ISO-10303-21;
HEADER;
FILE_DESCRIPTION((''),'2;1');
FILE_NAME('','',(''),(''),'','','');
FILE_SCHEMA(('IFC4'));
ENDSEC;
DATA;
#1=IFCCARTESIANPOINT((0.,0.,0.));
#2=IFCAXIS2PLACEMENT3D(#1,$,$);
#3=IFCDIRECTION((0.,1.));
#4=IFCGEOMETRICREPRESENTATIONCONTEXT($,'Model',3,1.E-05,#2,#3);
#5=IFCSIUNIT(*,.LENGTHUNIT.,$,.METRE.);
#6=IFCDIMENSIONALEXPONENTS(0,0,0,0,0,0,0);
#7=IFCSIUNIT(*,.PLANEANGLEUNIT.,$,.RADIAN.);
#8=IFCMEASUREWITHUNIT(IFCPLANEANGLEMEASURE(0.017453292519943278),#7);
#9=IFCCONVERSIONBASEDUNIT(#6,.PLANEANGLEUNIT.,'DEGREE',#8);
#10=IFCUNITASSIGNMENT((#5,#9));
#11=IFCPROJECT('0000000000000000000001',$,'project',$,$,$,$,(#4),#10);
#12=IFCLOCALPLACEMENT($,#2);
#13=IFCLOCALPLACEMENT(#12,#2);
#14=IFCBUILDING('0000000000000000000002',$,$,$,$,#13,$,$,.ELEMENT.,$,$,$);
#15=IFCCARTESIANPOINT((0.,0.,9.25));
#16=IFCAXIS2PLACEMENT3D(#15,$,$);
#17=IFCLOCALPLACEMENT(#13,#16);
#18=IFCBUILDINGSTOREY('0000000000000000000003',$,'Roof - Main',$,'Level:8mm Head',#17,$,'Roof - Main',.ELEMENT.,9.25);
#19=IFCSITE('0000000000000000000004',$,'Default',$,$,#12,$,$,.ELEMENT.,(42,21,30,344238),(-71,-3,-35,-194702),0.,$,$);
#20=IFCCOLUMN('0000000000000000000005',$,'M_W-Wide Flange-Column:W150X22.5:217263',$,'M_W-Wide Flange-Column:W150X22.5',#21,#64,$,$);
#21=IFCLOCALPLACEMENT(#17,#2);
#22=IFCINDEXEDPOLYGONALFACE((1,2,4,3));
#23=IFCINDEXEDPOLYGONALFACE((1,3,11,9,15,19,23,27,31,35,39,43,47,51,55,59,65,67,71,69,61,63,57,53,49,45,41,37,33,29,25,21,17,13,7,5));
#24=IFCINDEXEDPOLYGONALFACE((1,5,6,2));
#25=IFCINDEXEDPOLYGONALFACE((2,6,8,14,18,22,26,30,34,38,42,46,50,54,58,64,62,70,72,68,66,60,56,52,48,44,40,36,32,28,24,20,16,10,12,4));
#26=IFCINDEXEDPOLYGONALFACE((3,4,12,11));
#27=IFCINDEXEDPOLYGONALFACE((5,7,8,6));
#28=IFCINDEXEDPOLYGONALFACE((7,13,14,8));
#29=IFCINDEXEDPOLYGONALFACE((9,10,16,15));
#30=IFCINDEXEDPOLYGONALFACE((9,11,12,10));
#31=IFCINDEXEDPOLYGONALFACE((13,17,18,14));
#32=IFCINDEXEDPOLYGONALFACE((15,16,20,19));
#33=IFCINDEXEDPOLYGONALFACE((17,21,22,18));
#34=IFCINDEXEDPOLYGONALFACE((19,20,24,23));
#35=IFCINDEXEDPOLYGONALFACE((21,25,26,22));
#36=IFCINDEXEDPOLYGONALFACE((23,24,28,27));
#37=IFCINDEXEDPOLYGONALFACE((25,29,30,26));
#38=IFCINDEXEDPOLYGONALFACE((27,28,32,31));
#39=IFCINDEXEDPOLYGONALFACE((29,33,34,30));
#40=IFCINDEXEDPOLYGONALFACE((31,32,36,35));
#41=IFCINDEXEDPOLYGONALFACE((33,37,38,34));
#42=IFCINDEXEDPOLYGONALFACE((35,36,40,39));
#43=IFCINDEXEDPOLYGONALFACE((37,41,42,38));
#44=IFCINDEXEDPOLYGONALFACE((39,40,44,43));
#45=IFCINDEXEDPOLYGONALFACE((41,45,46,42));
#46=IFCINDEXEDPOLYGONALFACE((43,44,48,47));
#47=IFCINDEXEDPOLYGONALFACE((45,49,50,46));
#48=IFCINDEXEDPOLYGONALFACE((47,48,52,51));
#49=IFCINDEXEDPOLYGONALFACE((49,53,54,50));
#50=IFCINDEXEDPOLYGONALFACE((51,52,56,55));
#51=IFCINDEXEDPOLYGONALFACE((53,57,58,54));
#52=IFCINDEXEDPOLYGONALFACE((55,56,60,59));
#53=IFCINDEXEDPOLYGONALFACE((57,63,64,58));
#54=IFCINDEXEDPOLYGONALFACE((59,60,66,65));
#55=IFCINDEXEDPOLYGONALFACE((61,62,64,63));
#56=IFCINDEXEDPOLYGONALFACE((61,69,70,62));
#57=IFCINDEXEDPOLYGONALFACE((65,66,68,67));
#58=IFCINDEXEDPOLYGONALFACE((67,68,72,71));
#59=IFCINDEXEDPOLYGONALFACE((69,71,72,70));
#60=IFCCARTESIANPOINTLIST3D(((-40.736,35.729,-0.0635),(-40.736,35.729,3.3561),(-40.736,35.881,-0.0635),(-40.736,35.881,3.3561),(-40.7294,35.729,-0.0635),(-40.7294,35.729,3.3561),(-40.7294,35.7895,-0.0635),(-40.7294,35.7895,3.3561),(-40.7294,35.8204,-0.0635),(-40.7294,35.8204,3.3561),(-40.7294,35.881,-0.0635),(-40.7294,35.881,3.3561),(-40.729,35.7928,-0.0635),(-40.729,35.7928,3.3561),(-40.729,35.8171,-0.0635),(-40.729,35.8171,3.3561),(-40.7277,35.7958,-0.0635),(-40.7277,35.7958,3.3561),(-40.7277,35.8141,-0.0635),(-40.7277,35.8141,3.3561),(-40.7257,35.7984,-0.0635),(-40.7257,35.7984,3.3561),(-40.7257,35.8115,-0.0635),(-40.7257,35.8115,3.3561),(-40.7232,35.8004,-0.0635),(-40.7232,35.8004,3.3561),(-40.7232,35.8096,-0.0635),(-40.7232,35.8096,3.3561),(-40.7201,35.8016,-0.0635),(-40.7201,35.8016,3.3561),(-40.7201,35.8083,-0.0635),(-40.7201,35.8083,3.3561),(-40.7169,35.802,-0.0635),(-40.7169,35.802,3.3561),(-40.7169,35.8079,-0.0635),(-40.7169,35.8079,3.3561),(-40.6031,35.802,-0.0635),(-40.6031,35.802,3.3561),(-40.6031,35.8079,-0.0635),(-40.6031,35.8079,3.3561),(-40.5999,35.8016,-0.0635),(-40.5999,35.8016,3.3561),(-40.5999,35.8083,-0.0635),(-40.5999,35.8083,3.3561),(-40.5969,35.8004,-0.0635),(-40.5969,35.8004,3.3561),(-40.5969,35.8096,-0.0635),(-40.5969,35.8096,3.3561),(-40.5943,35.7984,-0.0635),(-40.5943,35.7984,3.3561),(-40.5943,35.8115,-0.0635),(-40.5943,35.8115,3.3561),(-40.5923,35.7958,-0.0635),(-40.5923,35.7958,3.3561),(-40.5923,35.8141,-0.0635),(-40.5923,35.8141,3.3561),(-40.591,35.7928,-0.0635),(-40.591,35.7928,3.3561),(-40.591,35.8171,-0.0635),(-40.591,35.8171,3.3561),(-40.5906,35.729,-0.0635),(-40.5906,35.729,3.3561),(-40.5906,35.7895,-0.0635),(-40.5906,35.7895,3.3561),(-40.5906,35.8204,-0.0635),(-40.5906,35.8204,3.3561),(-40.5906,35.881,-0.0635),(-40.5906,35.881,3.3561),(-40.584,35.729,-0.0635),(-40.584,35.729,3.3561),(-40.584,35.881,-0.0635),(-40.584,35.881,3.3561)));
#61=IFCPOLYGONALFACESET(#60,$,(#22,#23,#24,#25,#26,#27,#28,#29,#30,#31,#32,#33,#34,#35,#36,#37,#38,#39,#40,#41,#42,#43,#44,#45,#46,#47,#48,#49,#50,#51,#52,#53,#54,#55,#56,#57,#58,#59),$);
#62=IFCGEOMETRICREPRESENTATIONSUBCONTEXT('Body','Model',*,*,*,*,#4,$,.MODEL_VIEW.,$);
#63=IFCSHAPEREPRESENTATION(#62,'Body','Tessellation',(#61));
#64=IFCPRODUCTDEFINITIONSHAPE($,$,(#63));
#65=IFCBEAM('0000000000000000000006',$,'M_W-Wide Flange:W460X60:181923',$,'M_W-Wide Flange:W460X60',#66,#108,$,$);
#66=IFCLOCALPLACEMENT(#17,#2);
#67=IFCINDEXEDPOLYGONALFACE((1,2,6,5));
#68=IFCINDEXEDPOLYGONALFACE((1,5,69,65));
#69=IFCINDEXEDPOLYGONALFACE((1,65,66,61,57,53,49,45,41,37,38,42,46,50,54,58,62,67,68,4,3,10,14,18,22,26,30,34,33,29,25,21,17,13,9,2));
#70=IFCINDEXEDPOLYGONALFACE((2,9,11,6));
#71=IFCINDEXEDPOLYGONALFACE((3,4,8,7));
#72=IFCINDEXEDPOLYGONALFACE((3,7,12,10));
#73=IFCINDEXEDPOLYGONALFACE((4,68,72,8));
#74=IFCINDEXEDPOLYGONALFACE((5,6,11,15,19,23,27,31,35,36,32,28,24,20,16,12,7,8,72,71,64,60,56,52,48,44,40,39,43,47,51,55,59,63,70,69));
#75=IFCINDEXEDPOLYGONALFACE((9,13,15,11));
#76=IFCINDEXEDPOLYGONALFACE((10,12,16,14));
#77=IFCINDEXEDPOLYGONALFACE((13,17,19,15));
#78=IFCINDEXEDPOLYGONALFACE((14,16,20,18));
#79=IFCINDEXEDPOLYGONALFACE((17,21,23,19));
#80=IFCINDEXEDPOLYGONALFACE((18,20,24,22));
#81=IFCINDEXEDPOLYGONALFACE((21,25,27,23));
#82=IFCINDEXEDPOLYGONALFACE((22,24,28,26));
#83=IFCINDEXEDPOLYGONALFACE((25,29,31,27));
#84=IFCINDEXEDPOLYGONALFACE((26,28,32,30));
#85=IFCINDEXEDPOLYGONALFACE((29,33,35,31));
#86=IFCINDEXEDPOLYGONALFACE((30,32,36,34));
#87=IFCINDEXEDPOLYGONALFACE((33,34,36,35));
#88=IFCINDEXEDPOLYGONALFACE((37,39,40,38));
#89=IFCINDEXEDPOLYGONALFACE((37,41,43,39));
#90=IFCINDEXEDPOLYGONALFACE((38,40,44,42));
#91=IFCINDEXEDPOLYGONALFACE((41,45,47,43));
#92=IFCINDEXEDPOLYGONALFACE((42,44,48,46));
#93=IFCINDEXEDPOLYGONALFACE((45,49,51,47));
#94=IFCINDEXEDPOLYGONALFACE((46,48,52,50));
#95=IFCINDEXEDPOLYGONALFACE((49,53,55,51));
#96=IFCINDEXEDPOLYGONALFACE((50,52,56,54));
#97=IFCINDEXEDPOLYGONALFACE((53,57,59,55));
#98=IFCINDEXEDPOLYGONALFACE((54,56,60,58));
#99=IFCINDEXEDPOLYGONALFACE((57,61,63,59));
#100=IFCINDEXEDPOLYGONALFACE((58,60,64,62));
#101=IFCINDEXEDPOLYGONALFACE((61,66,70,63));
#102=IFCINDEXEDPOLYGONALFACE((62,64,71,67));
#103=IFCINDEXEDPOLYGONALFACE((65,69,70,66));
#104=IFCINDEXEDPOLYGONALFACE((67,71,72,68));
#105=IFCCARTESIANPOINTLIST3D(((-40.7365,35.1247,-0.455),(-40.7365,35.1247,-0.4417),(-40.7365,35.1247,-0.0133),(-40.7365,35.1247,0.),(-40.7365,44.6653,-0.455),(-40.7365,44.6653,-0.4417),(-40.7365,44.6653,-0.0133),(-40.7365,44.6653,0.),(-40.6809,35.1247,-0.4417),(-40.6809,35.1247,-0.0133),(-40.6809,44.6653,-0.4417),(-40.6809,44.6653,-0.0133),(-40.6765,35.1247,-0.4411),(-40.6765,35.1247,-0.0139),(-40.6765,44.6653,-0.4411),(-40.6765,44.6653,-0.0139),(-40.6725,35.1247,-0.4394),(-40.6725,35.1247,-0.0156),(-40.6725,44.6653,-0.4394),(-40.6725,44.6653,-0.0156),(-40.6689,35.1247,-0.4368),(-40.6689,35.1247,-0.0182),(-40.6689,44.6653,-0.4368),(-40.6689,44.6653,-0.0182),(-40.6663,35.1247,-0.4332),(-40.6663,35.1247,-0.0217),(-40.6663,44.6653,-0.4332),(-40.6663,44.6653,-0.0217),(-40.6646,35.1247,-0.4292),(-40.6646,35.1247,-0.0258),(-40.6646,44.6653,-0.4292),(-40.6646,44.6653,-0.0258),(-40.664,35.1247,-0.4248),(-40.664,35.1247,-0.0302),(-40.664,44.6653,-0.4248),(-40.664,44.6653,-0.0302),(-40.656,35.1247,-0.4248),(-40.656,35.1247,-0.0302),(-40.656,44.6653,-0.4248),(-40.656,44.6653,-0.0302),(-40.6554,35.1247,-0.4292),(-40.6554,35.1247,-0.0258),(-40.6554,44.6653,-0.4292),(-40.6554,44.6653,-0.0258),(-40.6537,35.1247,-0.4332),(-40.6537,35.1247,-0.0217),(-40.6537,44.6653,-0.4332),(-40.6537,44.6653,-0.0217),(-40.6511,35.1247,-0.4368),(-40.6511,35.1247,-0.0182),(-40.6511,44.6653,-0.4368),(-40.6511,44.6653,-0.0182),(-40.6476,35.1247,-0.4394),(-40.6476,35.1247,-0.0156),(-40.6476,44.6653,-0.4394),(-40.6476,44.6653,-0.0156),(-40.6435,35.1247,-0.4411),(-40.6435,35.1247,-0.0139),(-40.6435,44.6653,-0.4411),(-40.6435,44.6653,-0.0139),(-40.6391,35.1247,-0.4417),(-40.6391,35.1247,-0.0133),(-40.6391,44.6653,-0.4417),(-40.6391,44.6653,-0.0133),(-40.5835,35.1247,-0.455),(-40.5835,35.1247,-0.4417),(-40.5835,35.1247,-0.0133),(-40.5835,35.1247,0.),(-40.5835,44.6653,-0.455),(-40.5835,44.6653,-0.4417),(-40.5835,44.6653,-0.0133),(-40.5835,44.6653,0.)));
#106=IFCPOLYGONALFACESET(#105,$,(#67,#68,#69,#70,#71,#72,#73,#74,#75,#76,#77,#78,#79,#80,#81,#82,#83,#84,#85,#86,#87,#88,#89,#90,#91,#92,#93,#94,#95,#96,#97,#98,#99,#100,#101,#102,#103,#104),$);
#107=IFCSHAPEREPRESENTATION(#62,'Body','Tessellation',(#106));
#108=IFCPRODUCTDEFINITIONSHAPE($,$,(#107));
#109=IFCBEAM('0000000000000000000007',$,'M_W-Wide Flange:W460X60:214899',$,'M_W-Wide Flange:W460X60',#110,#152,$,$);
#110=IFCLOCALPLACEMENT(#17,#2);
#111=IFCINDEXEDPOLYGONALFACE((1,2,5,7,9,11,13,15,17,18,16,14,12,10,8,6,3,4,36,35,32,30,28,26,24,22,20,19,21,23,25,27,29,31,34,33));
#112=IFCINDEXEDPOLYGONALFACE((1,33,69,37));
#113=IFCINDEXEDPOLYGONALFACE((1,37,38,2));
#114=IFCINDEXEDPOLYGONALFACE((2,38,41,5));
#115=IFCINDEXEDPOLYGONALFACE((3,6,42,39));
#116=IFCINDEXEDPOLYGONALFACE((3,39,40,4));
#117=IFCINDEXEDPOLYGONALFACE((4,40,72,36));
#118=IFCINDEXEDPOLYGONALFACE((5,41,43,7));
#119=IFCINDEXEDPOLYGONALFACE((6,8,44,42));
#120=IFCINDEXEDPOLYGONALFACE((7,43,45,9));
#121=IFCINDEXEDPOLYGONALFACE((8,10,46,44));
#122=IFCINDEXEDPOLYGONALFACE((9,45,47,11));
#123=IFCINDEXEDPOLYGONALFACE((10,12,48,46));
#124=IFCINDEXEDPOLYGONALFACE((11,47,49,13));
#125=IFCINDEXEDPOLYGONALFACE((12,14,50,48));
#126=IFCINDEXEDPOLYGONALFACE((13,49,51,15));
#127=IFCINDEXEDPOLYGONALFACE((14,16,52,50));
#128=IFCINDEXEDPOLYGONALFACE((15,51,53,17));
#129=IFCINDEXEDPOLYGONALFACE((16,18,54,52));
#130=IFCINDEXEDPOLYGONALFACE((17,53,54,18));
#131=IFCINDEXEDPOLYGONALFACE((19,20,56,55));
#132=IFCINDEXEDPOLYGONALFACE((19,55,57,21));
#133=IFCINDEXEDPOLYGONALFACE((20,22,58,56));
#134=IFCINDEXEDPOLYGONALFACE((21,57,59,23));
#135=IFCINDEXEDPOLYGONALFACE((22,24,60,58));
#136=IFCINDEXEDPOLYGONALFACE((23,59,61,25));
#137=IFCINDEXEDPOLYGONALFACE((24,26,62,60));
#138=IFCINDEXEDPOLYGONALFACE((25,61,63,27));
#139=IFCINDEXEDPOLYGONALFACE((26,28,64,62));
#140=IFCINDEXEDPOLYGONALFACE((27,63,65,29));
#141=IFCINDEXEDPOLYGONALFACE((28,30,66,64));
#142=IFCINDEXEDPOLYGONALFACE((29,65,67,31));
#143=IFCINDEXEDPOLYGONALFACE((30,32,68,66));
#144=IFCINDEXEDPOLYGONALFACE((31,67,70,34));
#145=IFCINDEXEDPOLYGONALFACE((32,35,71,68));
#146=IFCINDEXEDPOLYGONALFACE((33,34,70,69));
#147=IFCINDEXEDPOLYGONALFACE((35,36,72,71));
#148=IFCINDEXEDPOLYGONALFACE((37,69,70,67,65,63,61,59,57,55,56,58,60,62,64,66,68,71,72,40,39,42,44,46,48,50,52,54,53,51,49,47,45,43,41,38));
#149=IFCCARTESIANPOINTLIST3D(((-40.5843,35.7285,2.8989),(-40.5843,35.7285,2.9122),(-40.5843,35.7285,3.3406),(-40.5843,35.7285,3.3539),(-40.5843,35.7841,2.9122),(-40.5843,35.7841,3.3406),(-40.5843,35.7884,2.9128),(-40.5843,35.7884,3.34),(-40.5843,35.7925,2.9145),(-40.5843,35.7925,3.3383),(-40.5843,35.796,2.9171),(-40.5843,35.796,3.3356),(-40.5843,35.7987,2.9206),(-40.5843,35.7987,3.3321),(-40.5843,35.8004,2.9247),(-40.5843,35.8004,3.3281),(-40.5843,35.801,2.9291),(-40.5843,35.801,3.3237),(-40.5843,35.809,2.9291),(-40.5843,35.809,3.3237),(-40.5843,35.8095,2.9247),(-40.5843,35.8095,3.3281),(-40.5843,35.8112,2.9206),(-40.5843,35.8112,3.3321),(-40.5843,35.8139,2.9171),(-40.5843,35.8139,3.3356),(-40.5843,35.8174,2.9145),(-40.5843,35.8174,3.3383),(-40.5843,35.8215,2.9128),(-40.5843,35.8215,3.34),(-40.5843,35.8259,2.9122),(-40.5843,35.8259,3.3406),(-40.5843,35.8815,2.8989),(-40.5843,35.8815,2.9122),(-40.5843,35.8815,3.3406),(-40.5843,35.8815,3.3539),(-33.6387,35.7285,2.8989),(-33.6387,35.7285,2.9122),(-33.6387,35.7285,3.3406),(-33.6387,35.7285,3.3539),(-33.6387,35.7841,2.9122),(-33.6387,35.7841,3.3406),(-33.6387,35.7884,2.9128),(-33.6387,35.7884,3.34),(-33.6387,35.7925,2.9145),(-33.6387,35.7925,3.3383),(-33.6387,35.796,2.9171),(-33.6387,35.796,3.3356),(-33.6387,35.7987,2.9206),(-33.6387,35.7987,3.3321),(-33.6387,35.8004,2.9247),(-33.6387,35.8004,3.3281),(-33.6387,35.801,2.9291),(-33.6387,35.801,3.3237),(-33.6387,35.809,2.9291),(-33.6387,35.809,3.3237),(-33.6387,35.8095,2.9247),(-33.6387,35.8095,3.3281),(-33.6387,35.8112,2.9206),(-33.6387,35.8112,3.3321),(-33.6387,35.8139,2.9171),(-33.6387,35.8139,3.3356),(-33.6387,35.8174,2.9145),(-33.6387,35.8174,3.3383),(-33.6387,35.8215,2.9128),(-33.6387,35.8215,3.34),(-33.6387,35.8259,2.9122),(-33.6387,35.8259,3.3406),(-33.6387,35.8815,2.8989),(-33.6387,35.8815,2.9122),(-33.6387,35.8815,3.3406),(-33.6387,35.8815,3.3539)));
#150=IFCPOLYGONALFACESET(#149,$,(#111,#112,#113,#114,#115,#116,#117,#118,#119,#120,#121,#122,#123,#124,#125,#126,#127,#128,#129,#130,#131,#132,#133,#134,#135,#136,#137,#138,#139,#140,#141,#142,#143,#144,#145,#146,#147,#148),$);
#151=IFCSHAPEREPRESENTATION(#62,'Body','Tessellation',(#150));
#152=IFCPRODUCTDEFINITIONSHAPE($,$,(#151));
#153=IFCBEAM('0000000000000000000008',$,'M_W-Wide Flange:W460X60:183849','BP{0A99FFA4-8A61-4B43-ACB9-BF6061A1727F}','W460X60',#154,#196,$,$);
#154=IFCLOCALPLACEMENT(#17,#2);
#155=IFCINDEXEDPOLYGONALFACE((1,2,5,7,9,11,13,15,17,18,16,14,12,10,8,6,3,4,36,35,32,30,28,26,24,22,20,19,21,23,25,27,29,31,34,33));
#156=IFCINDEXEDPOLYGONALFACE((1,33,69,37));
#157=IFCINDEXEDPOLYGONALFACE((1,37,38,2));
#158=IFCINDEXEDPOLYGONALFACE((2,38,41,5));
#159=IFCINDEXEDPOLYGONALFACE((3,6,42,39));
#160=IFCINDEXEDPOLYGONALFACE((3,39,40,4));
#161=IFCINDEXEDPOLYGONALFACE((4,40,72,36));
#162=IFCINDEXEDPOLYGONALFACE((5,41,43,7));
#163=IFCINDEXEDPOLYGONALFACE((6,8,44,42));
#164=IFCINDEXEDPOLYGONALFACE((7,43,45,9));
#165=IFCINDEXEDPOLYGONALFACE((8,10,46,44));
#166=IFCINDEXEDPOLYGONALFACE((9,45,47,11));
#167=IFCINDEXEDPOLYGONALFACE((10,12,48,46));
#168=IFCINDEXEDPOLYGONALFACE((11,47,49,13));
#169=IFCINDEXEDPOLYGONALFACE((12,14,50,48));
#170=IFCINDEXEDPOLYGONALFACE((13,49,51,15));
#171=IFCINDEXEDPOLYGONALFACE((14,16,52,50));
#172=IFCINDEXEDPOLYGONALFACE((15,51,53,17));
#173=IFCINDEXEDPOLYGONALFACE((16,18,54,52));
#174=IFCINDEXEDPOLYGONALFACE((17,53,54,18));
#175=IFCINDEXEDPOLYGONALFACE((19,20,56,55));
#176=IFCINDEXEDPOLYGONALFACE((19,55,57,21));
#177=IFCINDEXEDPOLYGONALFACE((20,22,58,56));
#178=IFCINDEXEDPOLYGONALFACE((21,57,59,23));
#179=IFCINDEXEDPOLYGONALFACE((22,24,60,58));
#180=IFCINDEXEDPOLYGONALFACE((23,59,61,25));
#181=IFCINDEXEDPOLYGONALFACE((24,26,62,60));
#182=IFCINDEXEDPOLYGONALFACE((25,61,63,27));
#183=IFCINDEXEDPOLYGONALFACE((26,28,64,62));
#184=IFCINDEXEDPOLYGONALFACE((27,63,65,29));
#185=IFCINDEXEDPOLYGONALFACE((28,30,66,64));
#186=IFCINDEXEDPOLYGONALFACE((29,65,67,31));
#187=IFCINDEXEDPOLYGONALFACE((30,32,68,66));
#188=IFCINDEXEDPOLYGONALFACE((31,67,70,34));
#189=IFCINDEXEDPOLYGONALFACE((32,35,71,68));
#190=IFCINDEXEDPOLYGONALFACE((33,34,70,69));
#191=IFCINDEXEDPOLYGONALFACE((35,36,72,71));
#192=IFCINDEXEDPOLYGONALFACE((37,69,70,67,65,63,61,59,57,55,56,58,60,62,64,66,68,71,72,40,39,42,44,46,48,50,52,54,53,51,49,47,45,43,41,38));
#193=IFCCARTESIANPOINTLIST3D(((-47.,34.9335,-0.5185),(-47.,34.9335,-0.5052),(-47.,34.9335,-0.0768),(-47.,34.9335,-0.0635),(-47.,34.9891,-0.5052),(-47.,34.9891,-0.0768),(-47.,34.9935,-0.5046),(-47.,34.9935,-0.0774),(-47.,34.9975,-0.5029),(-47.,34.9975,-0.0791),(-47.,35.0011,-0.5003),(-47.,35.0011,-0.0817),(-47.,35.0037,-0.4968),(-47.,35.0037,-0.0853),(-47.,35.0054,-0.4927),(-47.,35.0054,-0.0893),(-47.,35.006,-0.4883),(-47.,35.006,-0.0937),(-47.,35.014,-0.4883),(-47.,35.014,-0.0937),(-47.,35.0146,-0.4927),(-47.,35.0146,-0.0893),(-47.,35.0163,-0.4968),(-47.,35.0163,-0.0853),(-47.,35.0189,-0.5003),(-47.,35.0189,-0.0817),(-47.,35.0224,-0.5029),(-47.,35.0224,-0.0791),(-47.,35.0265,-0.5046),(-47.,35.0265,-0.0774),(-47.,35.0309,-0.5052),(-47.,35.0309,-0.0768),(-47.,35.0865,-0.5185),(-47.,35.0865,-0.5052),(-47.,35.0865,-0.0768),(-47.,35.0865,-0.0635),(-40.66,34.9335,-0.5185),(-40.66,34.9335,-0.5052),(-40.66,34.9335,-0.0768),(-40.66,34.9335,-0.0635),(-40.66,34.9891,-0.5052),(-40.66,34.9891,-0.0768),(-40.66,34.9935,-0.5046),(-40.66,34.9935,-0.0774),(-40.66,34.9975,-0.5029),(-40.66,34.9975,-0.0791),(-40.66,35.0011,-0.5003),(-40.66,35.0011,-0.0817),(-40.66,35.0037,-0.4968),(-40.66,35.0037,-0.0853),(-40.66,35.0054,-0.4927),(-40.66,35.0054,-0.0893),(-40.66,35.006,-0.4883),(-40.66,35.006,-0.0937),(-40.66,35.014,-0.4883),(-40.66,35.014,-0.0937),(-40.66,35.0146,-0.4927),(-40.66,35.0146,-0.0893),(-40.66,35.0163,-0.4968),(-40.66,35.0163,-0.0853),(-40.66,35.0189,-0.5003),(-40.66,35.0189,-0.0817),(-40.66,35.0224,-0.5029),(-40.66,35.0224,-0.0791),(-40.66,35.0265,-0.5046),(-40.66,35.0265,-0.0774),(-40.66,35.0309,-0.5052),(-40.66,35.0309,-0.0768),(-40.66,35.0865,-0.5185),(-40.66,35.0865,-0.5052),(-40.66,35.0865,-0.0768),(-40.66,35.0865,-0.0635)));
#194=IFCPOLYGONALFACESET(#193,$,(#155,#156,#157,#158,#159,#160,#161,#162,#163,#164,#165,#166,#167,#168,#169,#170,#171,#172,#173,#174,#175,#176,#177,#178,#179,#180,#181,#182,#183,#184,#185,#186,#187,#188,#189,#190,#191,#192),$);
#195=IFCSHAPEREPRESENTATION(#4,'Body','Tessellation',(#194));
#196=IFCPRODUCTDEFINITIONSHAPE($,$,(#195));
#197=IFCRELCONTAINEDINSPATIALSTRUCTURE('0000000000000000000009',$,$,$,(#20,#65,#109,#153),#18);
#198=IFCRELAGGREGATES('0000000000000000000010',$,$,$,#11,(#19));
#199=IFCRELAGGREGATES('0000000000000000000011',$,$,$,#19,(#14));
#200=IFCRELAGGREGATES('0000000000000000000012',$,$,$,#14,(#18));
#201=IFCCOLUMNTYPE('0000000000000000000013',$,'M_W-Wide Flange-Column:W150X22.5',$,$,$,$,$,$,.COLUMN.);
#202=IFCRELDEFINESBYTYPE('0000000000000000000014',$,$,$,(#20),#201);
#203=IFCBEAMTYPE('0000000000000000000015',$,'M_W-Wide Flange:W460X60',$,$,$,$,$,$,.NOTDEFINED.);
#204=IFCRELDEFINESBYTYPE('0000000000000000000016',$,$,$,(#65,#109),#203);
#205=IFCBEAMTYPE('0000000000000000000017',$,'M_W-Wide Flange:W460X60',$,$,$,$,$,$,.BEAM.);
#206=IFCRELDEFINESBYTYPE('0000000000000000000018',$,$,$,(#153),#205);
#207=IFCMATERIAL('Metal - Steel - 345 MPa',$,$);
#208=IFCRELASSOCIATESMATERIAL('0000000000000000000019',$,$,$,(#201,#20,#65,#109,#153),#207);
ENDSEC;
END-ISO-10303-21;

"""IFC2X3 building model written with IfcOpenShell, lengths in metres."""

from ifc_helpers import new_model, entity, si_unit, converted_unit, direction, frame, frame_2d, origin, origin_2d, place, context, subcontext, project, spatial, i_section, extrude, source, transform, mapped, material, type_object, type_shapes, element, save


model = new_model("IFC2X3")

# Units and contexts
model_context = context("Model", 3, precision=1e-05, world=origin(), true_north=direction((0.0, 1.0)))
body_context = subcontext(model_context, "Body", "Model", "MODEL_VIEW")
ifc_project = project(units=[si_unit("LENGTHUNIT", "METRE"), converted_unit("PLANEANGLEUNIT", "DEGREE", entity("IfcPlaneAngleMeasure", 0.017453292519943278), si_unit("PLANEANGLEUNIT", "RADIAN"), dimensions=[0, 0, 0, 0, 0, 0, 0])], contexts=[model_context])

# Site, building, storey
site_placement = place(None, origin())
site = spatial("IfcSite", under=ifc_project, at=site_placement, Name="Default", CompositionType="ELEMENT", RefLatitude=(42, 21, 30, 344238), RefLongitude=(-71, -3, -35, -194702), RefElevation=0.0)
building_placement = place(site_placement, origin())
building = spatial("IfcBuilding", under=site, at=building_placement, CompositionType="ELEMENT")
storey_placement = place(building_placement, frame((0.0, 0.0, 9.25)))
storey = spatial("IfcBuildingStorey", under=building, at=storey_placement, Name="Roof - Main", ObjectType="Level:8mm Head", LongName="Roof - Main", CompositionType="ELEMENT", Elevation=9.25)

# Column
ifc_material_1 = material(Name="Metal - Steel - 345 MPa")
column_type = type_object("IfcColumnType", Name="M_W-Wide Flange-Column:W150X22.5", PredefinedType="COLUMN", material=ifc_material_1)
shared_shape_1 = source(origin(), body_context, "Body", "SweptSolid", [
    extrude(i_section(OverallWidth=0.152, OverallDepth=0.152, WebThickness=0.0058, FlangeThickness=0.0066, FilletRadius=0.0125, at=frame_2d((0.0, 0.0), x_axis=(1.0, 0.0))), frame((0.0, 0.0, 9.1865), z_axis=(0.0, 0.0, 1.0), x_axis=(-1.0, 0.0, 0.0)), (0.0, 0.0, 1.0), 3.4196),
])
type_shapes(column_type, [shared_shape_1])
column_placement = place(storey_placement, frame((-40.66, 35.805, -9.25), z_axis=(0.0, 0.0, 1.0), x_axis=(0.0, 1.0, 0.0)))
element("IfcColumn", 1, at=column_placement, inside=storey, type_object=column_type, material=ifc_material_1, Name="M_W-Wide Flange-Column:W150X22.5:217263", ObjectType="M_W-Wide Flange-Column:W150X22.5", context=body_context, shape_type="MappedRepresentation", body=[
    mapped(shared_shape_1, transform((0.0, 0.0, 0.0), scale=1.0)),
])

# Beams
beam_type_1 = type_object("IfcBeamType", Name="M_W-Wide Flange:W460X60", PredefinedType="NOTDEFINED")
beam_1_placement = place(storey_placement, frame((-40.66, 35.01, 0.0), z_axis=(0.0, 0.0, 1.0), x_axis=(0.0, 1.0, 0.0)))
element("IfcBeam", 2, at=beam_1_placement, inside=storey, type_object=beam_type_1, material=ifc_material_1, Name="M_W-Wide Flange:W460X60:181923", ObjectType="M_W-Wide Flange:W460X60", context=body_context, shape_type="SweptSolid", body=[
    extrude(i_section(OverallWidth=0.153, OverallDepth=0.455, WebThickness=0.008, FlangeThickness=0.0133, FilletRadius=0.0169, at=frame_2d((0.0, 0.0), x_axis=(0.0, 1.0))), frame((0.1147, 0.0, -0.2275), z_axis=(1.0, 0.0, 0.0), x_axis=(0.0, 0.0, -1.0)), (0.0, 0.0, 1.0), 9.5406),
])
beam_2_placement = place(storey_placement, frame((-40.74, 35.805, 3.3539)))
element("IfcBeam", 3, at=beam_2_placement, inside=storey, type_object=beam_type_1, material=ifc_material_1, Name="M_W-Wide Flange:W460X60:214899", ObjectType="M_W-Wide Flange:W460X60", context=body_context, shape_type="SweptSolid", body=[
    extrude(i_section(OverallWidth=0.153, OverallDepth=0.455, WebThickness=0.008, FlangeThickness=0.0133, FilletRadius=0.0169, at=frame_2d((0.0, 0.0), x_axis=(0.0, 1.0))), frame((0.1557, 0.0, -0.2275), z_axis=(1.0, 0.0, 0.0), x_axis=(0.0, 0.0, -1.0)), (0.0, 0.0, 1.0), 6.9456),
])

# Beam
beam_type_2 = type_object("IfcBeamType", Name="M_W-Wide Flange:W460X60", PredefinedType="BEAM")
beam_3_placement = place(storey_placement, frame((-40.66, 35.01, -0.291), z_axis=(1.0, 0.0, 0.0), x_axis=(0.0, 1.0, 0.0)))
element("IfcBeam", 4, at=beam_3_placement, inside=storey, type_object=beam_type_2, material=ifc_material_1, Name="M_W-Wide Flange:W460X60:183849", Description="BP{0A99FFA4-8A61-4B43-ACB9-BF6061A1727F}", ObjectType="W460X60", context=model_context, shape_type="SweptSolid", body=[
    extrude(i_section(OverallWidth=0.153, OverallDepth=0.455, WebThickness=0.008, FlangeThickness=0.0133, FilletRadius=0.0169, at=origin_2d()), origin(), (0.0, 0.0, -1.0), 6.34),
])

save(model, "model.ifc")
